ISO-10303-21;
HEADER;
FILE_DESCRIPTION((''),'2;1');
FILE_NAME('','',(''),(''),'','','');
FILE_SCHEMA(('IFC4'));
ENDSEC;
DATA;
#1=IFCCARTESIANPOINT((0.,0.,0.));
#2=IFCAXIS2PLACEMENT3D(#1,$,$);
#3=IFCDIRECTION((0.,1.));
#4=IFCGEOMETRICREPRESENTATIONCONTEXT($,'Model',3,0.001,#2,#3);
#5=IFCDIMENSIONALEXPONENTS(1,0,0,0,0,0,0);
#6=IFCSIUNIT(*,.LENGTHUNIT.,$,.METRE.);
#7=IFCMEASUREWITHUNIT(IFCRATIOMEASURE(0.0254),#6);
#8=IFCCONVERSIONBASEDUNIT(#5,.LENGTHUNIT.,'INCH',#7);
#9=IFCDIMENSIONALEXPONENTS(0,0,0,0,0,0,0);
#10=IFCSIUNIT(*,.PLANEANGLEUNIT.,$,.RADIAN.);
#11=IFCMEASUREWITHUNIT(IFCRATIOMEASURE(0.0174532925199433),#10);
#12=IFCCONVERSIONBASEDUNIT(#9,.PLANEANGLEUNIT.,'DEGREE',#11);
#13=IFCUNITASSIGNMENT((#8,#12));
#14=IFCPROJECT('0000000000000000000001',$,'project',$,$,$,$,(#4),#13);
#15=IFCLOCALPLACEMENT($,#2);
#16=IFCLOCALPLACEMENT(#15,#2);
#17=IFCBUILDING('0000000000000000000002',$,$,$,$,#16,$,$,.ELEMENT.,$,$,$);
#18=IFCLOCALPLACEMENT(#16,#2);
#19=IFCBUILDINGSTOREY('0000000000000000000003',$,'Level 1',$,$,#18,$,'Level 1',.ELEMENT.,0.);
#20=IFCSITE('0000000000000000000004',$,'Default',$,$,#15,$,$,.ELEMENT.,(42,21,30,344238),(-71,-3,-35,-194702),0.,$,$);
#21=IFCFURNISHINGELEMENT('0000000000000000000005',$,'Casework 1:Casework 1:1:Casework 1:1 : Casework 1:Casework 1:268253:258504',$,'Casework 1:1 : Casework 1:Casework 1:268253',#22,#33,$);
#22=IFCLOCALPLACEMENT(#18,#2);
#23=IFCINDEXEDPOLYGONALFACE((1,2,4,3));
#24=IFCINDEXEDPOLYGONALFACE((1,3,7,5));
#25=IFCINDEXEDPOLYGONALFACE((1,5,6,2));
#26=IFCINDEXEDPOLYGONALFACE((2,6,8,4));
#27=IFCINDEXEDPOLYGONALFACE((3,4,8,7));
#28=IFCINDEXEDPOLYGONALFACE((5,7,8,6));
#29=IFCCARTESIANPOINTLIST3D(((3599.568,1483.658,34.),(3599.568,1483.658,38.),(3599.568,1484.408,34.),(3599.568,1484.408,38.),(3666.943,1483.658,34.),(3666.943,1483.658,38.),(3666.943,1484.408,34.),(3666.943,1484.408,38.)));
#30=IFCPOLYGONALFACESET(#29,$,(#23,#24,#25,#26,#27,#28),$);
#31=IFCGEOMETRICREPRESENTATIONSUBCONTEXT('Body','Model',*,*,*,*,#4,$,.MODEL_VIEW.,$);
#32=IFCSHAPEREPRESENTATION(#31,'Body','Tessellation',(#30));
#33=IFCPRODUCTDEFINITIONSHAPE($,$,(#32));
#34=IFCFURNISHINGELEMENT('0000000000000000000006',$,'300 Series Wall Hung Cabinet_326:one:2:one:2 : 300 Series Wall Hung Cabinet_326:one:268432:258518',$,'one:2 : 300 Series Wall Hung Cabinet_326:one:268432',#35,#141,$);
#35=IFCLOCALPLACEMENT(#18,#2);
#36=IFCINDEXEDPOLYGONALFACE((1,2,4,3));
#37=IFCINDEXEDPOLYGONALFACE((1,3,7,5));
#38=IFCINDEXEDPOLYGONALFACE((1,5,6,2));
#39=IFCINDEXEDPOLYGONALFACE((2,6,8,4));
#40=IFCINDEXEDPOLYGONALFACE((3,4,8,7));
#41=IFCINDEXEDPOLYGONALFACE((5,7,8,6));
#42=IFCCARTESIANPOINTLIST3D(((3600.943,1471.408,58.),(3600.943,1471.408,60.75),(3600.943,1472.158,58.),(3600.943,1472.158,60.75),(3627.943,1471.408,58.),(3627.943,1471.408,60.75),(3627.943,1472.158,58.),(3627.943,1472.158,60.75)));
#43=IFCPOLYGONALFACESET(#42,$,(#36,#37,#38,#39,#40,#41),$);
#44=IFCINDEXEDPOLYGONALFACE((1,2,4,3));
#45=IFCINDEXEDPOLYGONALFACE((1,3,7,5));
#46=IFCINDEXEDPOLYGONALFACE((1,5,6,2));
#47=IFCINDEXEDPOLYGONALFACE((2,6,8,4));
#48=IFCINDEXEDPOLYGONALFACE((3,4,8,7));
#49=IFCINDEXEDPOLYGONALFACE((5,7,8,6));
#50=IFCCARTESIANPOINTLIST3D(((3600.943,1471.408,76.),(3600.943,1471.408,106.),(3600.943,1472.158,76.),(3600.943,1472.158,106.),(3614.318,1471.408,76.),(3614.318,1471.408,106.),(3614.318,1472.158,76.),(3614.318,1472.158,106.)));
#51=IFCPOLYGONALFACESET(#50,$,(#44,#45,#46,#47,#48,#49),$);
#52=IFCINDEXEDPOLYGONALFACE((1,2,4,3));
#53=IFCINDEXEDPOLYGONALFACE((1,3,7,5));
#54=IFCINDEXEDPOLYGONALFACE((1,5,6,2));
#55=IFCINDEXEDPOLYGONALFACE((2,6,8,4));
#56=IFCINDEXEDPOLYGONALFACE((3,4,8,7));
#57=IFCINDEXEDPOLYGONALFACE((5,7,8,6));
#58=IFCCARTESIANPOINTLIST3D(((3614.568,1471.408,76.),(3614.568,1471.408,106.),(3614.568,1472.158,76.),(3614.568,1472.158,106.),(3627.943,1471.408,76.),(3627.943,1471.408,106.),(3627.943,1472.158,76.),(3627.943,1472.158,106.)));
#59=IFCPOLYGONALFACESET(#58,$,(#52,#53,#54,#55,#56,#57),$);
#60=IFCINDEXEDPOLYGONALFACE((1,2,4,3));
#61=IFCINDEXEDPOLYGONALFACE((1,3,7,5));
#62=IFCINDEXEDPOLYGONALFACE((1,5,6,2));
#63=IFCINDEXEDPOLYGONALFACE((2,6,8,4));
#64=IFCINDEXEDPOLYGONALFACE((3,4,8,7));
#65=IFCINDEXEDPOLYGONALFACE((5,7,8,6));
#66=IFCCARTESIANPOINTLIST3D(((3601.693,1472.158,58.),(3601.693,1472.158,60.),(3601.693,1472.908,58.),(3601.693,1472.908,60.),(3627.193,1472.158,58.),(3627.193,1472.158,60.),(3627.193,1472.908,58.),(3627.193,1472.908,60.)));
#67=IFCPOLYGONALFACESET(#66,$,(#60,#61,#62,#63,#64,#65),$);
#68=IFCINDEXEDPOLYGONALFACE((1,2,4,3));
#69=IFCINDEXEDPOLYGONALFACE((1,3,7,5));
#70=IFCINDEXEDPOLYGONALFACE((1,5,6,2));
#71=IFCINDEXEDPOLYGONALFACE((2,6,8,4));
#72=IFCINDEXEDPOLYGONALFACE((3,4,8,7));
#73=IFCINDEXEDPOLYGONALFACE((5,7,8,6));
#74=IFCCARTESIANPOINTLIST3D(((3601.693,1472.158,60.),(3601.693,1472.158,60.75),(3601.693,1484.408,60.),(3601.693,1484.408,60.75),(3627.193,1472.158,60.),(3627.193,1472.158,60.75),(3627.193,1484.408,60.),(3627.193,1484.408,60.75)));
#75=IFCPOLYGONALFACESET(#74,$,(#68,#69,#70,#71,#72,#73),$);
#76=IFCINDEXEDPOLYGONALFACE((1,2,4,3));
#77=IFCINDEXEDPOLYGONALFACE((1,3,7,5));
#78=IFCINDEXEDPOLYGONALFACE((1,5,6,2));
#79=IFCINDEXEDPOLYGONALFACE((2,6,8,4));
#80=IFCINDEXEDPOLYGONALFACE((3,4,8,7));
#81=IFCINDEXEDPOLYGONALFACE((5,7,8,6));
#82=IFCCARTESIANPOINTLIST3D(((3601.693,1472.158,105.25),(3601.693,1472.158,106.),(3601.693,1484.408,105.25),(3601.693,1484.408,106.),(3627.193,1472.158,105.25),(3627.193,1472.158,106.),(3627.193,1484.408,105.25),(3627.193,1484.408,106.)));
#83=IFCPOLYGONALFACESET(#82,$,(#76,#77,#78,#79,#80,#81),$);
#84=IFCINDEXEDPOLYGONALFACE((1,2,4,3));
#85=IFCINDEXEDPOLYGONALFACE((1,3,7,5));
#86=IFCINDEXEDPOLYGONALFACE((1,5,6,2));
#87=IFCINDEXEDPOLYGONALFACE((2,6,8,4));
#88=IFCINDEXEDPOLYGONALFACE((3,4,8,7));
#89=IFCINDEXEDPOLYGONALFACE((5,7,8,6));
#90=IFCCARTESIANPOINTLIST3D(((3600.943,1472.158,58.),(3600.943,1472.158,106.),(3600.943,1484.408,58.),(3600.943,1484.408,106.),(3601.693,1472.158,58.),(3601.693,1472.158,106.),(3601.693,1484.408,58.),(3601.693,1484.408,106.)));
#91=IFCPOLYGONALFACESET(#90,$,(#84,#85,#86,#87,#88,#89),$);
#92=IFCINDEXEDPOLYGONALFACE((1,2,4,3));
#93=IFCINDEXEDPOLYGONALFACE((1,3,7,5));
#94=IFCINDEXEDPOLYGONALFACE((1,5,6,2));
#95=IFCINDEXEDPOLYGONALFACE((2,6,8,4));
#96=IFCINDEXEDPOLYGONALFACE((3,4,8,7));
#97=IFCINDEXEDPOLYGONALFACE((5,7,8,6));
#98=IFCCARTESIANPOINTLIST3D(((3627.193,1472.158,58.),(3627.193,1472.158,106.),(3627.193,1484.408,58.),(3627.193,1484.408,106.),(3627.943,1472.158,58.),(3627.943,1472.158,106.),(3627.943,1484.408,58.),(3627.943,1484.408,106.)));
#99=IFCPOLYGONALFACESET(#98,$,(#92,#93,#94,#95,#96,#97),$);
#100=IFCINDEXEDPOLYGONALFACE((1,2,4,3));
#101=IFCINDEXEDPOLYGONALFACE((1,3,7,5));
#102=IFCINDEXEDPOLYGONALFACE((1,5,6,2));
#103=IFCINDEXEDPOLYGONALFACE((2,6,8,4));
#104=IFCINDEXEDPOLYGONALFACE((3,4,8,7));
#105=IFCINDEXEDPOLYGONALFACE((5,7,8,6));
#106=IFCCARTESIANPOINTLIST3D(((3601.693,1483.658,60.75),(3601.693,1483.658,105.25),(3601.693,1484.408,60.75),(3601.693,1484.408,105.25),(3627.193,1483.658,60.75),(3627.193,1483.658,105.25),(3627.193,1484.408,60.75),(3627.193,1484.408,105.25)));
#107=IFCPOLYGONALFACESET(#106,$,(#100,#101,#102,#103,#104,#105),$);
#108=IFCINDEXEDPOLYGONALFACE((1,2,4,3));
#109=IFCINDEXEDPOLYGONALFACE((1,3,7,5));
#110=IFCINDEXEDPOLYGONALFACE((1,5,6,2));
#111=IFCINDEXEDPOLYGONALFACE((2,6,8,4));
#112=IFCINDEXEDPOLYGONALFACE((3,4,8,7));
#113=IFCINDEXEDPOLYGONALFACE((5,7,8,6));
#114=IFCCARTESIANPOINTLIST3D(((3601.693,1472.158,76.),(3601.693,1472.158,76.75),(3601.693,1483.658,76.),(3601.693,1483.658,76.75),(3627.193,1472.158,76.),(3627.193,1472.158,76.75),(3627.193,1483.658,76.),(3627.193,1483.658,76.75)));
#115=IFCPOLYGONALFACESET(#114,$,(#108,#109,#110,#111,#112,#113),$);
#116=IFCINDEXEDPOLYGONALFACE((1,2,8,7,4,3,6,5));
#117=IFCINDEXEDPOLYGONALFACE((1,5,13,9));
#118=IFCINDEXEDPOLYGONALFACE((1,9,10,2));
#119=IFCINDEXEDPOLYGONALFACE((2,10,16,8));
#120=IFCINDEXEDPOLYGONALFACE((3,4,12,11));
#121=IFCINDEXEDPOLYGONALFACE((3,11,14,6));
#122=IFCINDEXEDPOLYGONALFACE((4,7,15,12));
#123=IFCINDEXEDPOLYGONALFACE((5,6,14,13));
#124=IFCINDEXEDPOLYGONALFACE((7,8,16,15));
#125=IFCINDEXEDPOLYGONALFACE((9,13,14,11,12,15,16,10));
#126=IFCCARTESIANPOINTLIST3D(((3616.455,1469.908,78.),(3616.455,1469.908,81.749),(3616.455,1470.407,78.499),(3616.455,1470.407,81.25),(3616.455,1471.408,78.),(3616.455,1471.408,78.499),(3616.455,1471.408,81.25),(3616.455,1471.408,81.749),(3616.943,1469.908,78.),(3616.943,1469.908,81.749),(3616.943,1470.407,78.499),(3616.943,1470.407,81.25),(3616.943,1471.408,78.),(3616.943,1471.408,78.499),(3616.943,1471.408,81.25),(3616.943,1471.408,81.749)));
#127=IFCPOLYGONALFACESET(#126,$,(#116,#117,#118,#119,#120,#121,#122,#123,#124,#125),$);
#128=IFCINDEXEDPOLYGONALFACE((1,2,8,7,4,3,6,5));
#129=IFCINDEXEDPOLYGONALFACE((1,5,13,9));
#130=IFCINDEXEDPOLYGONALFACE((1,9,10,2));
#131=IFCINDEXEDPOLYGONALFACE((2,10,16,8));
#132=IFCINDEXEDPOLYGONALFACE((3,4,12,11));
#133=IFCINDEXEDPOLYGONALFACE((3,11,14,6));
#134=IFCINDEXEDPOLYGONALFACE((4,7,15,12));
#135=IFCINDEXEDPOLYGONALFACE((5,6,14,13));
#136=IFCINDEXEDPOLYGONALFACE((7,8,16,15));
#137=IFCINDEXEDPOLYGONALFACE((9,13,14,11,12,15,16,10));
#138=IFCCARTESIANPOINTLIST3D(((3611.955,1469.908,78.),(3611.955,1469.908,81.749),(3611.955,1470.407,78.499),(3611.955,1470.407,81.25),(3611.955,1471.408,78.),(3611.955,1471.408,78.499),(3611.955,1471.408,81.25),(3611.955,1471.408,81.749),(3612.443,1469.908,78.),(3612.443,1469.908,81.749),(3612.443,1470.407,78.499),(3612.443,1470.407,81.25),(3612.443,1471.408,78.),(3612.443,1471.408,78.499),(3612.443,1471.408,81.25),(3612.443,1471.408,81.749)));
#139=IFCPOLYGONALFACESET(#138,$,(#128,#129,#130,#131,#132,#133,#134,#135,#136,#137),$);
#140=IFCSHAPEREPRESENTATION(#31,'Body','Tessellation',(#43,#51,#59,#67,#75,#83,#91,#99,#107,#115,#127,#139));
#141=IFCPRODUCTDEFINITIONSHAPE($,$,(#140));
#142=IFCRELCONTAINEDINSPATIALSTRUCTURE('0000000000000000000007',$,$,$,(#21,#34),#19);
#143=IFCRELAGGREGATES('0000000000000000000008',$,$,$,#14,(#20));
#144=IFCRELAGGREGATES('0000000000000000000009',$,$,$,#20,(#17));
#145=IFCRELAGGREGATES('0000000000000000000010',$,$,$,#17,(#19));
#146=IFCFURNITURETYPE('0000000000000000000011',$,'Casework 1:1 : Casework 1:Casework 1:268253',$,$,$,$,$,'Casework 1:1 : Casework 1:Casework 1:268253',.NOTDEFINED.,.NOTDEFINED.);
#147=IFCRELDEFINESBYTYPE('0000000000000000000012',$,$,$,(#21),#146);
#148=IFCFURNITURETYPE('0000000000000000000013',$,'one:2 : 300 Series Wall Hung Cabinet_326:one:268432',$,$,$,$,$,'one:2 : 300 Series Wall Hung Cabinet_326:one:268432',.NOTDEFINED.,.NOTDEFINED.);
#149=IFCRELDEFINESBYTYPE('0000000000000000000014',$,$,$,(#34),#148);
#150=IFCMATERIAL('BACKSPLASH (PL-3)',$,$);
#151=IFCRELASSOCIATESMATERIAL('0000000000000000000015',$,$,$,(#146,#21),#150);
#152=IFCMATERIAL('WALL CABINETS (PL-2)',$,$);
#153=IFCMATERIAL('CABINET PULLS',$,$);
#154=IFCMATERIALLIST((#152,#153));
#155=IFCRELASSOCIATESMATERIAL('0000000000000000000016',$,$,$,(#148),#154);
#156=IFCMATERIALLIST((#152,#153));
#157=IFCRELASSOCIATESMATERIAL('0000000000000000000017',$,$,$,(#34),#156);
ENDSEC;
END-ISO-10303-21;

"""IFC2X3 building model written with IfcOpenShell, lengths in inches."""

from ifc_helpers import new_model, entity, si_unit, converted_unit, direction, frame, frame_2d, origin, origin_2d_with_axis, place, context, subcontext, project, spatial, polyline, rectangle, outline, extrude, source, transform, mapped, material, material_list, type_object, type_shapes, element, save


model = new_model("IFC2X3")

# Units and contexts
model_context = context("Model", 3, precision=0.001, world=origin(), true_north=direction((0.0, 1.0)))
body_context = subcontext(model_context, "Body", "Model", "MODEL_VIEW")
ifc_project = project(units=[converted_unit("LENGTHUNIT", "INCH", entity("IfcRatioMeasure", 0.0254), si_unit("LENGTHUNIT", "METRE"), dimensions=[1, 0, 0, 0, 0, 0, 0]), converted_unit("PLANEANGLEUNIT", "DEGREE", entity("IfcRatioMeasure", 0.0174532925199433), si_unit("PLANEANGLEUNIT", "RADIAN"), dimensions=[0, 0, 0, 0, 0, 0, 0])], contexts=[model_context])

# Site, building, storey
site_placement = place(None, origin())
site = spatial("IfcSite", under=ifc_project, at=site_placement, Name="Default", CompositionType="ELEMENT", RefLatitude=(42, 21, 30, 344238), RefLongitude=(-71, -3, -35, -194702), RefElevation=0.0)
building_placement = place(site_placement, origin())
building = spatial("IfcBuilding", under=site, at=building_placement, CompositionType="ELEMENT")
storey_placement = place(building_placement, origin())
storey = spatial("IfcBuildingStorey", under=building, at=storey_placement, Name="Level 1", LongName="Level 1", CompositionType="ELEMENT", Elevation=0.0)

# Furnishing elements
ifc_material_1 = material(Name="BACKSPLASH (PL-3)")
furniture_type_1 = type_object("IfcFurnitureType", Name="Casework 1:1 : Casework 1:Casework 1:268253", ElementType="Casework 1:1 : Casework 1:Casework 1:268253", AssemblyPlace="NOTDEFINED", material=ifc_material_1)
shared_shape_1 = source(origin(), body_context, "Body", "SweptSolid", [
    extrude(rectangle(XDim=67.375, YDim=0.75, at=origin_2d_with_axis()), frame((3633.256, 1484.033, 34.0), z_axis=(0.0, 0.0, 1.0), x_axis=(-1.0, 0.0, 0.0)), (0.0, 0.0, 1.0), 4.0),
])
type_shapes(furniture_type_1, [shared_shape_1])
furnishing_1_placement = place(building_placement, origin())
element("IfcFurnishingElement", 1, at=furnishing_1_placement, inside=storey, type_object=furniture_type_1, material=ifc_material_1, Name="Casework 1:Casework 1:1:Casework 1:1 : Casework 1:Casework 1:268253:258504", ObjectType="Casework 1:1 : Casework 1:Casework 1:268253", context=body_context, shape_type="MappedRepresentation", body=[
    mapped(shared_shape_1, transform((0.0, 0.0, 0.0), scale=1.0)),
])
ifc_material_2 = material(Name="WALL CABINETS (PL-2)")
ifc_material_3 = material(Name="CABINET PULLS")
ifc_material_list_1 = material_list([ifc_material_2, ifc_material_3])
ifc_material_list_2 = material_list([ifc_material_2, ifc_material_3])
furniture_type_2 = type_object("IfcFurnitureType", Name="one:2 : 300 Series Wall Hung Cabinet_326:one:268432", ElementType="one:2 : 300 Series Wall Hung Cabinet_326:one:268432", AssemblyPlace="NOTDEFINED", material=ifc_material_list_2)
shared_shape_2 = source(origin(), body_context, "Body", "SweptSolid", [
    extrude(rectangle(XDim=27.0, YDim=0.75, at=origin_2d_with_axis()), frame((3614.443, 1471.783, 58.0)), (0.0, 0.0, 1.0), 2.75),
    extrude(rectangle(XDim=0.75, YDim=13.375, at=origin_2d_with_axis()), frame((3607.631, 1471.783, 76.0), z_axis=(0.0, 0.0, 1.0), x_axis=(0.0, 1.0, 0.0)), (0.0, 0.0, 1.0), 30.0),
    extrude(rectangle(XDim=0.75, YDim=13.375, at=origin_2d_with_axis()), frame((3621.256, 1471.783, 76.0), z_axis=(0.0, 0.0, 1.0), x_axis=(0.0, 1.0, 0.0)), (0.0, 0.0, 1.0), 30.0),
    extrude(rectangle(XDim=25.5, YDim=0.75, at=origin_2d_with_axis()), frame((3614.443, 1472.533, 58.0)), (0.0, 0.0, 1.0), 2.0),
    extrude(rectangle(XDim=12.25, YDim=25.5, at=origin_2d_with_axis()), frame((3614.443, 1478.283, 60.0), z_axis=(0.0, 0.0, 1.0), x_axis=(0.0, 1.0, 0.0)), (0.0, 0.0, 1.0), 0.75),
    extrude(rectangle(XDim=12.25, YDim=25.5, at=origin_2d_with_axis()), frame((3614.443, 1478.283, 105.25), z_axis=(0.0, 0.0, 1.0), x_axis=(0.0, 1.0, 0.0)), (0.0, 0.0, 1.0), 0.75),
    extrude(rectangle(XDim=12.25, YDim=0.75, at=origin_2d_with_axis()), frame((3601.318, 1478.283, 58.0), z_axis=(0.0, 0.0, 1.0), x_axis=(0.0, -1.0, 0.0)), (0.0, 0.0, 1.0), 48.0),
    extrude(rectangle(XDim=12.25, YDim=0.75, at=origin_2d_with_axis()), frame((3627.568, 1478.283, 58.0), z_axis=(0.0, 0.0, 1.0), x_axis=(0.0, -1.0, 0.0)), (0.0, 0.0, 1.0), 48.0),
    extrude(rectangle(XDim=25.5, YDim=0.75, at=origin_2d_with_axis()), frame((3614.443, 1484.033, 60.75)), (0.0, 0.0, 1.0), 44.5),
    extrude(rectangle(XDim=11.5, YDim=25.5, at=frame_2d((0.0, 0.0), x_axis=(1.0, 0.0))), frame((3614.443, 1477.908, 76.0), z_axis=(0.0, 0.0, 1.0), x_axis=(0.0, 1.0, 0.0)), (0.0, 0.0, 1.0), 0.75),
    extrude(outline(polyline([(-0.376, 1.375), (0.625, 1.375), (0.625, 1.874), (-0.874, 1.874), (-0.874, -1.874), (0.625, -1.874), (0.625, -1.375), (-0.376, -1.375), (-0.376, 1.375)])), frame((3616.455, 1470.783, 79.874), z_axis=(1.0, 0.0, 0.0), x_axis=(0.0, 1.0, 0.0)), (0.0, 0.0, 1.0), 0.488),
    extrude(outline(polyline([(-0.376, 1.375), (0.625, 1.375), (0.625, 1.874), (-0.874, 1.874), (-0.874, -1.874), (0.625, -1.874), (0.625, -1.375), (-0.376, -1.375), (-0.376, 1.375)])), frame((3611.955, 1470.783, 79.874), z_axis=(1.0, 0.0, 0.0), x_axis=(0.0, 1.0, 0.0)), (0.0, 0.0, 1.0), 0.488),
])
type_shapes(furniture_type_2, [shared_shape_2])
furnishing_2_placement = place(building_placement, origin())
element("IfcFurnishingElement", 2, at=furnishing_2_placement, inside=storey, type_object=furniture_type_2, material=ifc_material_list_1, Name="300 Series Wall Hung Cabinet_326:one:2:one:2 : 300 Series Wall Hung Cabinet_326:one:268432:258518", ObjectType="one:2 : 300 Series Wall Hung Cabinet_326:one:268432", context=body_context, shape_type="MappedRepresentation", body=[
    mapped(shared_shape_2, transform((0.0, 0.0, 0.0), scale=1.0)),
])

save(model, "model.ifc")
